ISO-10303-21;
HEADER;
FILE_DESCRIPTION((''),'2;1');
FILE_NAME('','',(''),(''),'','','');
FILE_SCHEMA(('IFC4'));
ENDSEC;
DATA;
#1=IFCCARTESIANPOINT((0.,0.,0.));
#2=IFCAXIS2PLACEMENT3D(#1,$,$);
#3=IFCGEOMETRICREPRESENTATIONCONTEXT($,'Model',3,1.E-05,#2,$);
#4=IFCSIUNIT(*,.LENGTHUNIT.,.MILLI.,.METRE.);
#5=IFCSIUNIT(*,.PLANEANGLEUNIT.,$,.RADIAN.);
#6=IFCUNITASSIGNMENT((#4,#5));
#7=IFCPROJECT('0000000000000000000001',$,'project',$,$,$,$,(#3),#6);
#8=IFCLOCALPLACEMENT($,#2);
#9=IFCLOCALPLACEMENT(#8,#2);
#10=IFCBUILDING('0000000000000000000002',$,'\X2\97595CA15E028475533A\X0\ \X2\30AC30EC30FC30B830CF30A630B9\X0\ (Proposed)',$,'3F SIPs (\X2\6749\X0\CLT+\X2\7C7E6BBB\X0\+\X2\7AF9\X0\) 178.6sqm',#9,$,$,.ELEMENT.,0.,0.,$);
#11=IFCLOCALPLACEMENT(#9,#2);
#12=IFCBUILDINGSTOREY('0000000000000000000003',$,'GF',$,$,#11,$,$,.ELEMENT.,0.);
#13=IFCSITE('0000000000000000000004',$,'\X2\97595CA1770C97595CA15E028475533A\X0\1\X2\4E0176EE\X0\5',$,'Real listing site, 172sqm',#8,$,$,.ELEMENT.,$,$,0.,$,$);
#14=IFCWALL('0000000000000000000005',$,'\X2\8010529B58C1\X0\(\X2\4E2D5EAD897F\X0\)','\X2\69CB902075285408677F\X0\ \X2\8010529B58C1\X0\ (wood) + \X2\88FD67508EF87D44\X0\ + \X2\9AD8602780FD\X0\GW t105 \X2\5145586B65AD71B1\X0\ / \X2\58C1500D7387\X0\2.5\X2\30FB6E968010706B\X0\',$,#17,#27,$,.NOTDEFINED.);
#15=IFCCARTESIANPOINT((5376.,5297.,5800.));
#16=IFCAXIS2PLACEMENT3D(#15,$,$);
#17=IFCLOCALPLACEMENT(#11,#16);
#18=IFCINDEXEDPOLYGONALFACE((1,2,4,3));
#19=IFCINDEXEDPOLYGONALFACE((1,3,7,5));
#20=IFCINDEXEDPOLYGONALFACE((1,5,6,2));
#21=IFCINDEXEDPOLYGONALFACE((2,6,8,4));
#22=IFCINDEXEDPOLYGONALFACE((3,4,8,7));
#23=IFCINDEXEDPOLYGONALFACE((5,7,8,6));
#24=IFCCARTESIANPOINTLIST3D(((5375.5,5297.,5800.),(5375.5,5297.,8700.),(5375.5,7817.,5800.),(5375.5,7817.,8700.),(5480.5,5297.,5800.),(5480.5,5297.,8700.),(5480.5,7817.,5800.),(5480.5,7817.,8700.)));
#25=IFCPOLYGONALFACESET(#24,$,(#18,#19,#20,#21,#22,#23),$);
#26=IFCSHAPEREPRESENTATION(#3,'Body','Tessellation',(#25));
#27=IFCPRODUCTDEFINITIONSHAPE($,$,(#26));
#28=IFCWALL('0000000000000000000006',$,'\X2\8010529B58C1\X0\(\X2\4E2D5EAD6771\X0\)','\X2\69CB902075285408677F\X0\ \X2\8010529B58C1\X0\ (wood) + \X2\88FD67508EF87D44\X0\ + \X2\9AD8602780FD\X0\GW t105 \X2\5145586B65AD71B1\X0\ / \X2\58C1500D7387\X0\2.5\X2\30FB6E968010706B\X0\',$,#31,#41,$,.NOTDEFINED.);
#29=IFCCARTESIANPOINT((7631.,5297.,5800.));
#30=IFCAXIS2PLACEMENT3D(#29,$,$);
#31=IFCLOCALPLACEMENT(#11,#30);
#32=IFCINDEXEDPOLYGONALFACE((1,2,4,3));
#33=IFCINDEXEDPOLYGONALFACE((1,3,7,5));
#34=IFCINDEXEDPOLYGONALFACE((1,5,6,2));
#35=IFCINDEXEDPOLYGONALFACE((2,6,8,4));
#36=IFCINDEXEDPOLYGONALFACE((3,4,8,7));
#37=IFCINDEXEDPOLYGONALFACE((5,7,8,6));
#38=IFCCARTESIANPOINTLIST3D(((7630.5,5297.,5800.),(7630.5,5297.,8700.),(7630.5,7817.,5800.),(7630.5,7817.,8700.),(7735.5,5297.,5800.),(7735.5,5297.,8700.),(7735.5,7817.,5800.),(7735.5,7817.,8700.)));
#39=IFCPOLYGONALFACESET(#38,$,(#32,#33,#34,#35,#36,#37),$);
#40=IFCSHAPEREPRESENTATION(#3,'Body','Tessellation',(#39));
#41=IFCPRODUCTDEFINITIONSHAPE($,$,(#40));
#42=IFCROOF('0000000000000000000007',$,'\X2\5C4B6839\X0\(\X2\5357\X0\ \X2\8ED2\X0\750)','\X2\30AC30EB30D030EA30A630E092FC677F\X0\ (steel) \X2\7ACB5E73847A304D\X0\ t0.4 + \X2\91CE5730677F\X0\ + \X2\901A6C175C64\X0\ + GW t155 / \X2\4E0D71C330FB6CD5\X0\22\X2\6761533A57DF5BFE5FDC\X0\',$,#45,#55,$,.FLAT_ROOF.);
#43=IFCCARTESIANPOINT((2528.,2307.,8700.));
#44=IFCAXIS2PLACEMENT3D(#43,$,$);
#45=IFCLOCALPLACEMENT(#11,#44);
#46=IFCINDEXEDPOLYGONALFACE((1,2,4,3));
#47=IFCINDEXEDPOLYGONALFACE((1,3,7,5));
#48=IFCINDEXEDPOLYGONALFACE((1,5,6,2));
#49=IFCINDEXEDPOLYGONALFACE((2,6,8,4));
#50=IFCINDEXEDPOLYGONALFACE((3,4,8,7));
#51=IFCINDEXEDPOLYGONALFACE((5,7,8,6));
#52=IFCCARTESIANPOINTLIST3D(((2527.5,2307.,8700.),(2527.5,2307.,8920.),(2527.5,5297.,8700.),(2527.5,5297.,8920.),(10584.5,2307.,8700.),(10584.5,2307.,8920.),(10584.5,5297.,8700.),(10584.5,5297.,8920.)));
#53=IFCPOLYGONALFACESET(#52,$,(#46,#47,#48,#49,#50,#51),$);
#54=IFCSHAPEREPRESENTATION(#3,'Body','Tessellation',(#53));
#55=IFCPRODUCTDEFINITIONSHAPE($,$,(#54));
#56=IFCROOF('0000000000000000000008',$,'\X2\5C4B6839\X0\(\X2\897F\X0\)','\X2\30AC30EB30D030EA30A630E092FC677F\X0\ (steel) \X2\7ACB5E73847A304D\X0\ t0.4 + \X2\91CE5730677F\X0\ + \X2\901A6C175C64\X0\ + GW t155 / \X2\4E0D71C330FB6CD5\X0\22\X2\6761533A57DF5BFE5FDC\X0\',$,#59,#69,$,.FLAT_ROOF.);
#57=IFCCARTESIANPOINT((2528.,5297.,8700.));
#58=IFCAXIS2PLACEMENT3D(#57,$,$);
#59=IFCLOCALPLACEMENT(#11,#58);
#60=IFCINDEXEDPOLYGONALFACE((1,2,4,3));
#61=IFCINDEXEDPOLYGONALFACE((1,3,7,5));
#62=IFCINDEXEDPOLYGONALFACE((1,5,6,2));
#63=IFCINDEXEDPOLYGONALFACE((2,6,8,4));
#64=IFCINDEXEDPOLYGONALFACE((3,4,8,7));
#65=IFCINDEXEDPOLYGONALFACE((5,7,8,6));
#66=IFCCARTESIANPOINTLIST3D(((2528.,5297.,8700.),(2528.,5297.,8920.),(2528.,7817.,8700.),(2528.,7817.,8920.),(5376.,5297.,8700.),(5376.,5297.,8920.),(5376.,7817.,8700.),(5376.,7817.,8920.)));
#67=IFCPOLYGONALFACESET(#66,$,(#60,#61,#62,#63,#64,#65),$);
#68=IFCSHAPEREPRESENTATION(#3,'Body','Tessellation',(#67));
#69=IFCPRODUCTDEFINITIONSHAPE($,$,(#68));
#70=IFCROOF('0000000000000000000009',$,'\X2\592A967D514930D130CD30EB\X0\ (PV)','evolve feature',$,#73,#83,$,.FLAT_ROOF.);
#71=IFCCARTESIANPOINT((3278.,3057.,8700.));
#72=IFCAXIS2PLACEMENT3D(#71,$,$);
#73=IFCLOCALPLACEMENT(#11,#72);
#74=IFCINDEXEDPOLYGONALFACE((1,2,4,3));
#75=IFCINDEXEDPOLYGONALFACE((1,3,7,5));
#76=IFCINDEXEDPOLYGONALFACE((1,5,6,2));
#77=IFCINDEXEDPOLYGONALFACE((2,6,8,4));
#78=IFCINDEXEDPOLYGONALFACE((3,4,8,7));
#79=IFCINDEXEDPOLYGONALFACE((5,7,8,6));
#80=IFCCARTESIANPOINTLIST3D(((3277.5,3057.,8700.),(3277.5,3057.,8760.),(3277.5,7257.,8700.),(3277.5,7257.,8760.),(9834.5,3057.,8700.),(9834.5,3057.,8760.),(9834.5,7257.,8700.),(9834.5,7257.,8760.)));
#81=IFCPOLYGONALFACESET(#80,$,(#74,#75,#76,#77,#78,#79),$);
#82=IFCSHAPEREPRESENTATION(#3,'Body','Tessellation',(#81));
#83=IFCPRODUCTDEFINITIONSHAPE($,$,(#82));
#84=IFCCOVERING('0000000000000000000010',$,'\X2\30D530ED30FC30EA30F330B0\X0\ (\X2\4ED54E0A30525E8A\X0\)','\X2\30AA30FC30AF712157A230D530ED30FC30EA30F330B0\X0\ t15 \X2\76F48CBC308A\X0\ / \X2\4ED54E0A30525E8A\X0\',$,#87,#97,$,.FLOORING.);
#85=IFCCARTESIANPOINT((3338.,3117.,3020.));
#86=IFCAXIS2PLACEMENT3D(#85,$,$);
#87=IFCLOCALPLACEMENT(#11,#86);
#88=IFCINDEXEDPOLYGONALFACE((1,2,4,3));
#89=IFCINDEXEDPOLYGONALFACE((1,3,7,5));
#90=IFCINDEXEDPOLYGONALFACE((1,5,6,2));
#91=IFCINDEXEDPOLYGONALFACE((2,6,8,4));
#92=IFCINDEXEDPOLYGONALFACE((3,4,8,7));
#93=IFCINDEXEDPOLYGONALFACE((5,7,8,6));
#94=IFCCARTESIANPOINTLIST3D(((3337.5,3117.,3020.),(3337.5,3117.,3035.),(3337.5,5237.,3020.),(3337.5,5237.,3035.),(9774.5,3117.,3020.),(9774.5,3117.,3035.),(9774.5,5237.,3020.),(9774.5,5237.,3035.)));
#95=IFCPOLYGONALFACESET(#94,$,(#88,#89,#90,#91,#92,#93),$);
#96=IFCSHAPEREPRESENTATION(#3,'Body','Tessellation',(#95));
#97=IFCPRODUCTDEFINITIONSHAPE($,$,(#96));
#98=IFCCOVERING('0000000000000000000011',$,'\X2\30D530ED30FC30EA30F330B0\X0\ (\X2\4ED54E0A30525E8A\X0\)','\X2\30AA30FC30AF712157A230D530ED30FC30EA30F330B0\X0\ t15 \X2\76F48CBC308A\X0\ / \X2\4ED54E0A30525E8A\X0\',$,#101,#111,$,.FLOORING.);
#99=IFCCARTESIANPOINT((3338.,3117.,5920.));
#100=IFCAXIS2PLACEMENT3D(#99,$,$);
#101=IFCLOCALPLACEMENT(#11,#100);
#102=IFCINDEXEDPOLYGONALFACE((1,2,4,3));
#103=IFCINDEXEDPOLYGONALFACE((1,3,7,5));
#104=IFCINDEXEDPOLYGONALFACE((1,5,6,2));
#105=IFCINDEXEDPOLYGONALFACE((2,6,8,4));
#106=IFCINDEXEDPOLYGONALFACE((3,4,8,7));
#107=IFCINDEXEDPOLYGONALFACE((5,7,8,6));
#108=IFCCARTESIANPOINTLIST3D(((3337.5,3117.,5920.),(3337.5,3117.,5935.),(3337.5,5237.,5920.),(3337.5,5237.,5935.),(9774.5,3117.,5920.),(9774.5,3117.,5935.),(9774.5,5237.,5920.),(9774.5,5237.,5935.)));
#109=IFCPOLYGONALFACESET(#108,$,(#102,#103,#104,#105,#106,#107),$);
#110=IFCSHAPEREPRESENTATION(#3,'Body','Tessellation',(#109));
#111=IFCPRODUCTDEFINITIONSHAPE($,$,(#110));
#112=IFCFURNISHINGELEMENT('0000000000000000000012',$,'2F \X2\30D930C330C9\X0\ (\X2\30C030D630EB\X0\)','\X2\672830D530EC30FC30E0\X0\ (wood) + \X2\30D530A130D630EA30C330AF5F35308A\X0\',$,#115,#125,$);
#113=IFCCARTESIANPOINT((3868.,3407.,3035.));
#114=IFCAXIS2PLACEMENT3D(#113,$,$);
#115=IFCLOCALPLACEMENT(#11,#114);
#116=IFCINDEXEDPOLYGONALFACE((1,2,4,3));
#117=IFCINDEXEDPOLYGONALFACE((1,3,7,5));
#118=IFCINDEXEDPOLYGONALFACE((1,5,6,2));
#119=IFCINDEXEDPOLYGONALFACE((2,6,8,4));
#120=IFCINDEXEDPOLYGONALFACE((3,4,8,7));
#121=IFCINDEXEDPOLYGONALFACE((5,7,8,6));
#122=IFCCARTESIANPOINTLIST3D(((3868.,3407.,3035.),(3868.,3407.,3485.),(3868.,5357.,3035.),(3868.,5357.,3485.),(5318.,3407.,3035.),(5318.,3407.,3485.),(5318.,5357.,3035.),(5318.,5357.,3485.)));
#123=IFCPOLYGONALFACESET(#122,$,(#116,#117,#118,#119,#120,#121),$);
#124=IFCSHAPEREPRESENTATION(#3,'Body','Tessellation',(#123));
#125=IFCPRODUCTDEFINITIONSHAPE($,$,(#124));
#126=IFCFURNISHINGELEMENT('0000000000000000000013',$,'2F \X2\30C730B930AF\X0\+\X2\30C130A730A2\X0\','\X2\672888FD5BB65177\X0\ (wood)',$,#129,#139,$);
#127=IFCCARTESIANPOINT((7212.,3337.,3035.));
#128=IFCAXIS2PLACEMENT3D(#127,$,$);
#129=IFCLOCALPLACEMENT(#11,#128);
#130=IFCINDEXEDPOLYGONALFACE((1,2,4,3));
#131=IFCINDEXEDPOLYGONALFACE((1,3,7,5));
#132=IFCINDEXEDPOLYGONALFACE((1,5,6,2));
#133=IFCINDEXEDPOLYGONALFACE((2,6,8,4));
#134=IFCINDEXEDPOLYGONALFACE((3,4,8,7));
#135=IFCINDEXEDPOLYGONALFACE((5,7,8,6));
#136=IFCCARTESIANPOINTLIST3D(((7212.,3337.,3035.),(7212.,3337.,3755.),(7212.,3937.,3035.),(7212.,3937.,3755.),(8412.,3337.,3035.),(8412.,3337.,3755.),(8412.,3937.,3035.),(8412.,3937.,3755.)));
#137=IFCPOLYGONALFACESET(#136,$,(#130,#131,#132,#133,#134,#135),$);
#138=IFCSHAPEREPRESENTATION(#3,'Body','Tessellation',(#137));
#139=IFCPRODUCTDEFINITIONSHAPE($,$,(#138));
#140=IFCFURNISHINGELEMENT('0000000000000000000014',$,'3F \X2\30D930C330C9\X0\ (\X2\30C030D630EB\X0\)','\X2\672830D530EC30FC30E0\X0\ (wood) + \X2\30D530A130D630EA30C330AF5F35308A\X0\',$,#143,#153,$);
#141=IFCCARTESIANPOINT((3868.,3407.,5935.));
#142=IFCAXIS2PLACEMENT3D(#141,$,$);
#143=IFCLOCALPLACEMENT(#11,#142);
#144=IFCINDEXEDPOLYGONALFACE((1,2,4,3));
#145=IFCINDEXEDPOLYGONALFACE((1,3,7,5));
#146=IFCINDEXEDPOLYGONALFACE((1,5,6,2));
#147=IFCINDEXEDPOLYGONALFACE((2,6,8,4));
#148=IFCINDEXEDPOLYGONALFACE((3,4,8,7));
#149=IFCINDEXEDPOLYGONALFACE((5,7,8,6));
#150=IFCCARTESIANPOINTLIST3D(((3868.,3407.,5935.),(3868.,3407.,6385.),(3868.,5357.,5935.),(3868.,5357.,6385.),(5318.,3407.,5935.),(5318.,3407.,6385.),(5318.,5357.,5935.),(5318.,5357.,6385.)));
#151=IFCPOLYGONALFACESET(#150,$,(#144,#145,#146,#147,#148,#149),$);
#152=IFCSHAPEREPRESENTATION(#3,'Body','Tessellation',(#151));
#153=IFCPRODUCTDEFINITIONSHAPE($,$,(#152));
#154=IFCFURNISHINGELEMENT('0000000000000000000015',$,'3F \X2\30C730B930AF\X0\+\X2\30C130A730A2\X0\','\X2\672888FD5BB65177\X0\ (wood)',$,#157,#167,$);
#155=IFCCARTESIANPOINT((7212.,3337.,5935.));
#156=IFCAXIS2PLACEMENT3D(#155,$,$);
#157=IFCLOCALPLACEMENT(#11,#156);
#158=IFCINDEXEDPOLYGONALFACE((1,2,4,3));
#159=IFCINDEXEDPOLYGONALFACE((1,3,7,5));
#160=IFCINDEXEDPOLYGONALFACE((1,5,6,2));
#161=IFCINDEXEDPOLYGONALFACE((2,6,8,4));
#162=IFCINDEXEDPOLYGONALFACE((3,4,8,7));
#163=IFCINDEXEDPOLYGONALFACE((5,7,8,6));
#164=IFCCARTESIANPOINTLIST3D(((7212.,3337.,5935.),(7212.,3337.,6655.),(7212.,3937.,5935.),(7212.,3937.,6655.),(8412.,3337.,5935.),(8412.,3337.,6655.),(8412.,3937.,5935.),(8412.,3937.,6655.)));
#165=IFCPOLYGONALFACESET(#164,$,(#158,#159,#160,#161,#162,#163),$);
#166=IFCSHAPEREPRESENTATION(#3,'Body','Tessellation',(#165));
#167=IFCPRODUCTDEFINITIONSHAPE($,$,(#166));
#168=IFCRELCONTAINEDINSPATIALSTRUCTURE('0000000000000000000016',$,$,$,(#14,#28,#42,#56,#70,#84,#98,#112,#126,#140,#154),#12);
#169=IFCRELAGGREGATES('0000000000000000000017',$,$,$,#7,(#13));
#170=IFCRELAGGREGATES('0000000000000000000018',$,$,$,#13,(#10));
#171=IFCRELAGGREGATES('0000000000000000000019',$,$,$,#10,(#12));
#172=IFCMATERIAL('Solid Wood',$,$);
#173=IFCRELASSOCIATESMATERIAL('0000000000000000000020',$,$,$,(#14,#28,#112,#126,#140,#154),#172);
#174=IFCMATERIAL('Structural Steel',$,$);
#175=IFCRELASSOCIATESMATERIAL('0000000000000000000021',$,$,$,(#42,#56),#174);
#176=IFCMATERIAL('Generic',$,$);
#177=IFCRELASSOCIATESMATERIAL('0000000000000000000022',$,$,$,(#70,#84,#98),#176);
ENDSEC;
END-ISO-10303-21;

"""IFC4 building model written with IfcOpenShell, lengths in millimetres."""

from ifc_helpers import new_model, si_unit, frame, frame_2d, origin, place, context, project, spatial, rectangle, extrude, material, element, save


model = new_model("IFC4")

# Units and contexts
model_context = context("Model", 3, precision=1e-05, world=origin())
ifc_project = project(units=[si_unit("LENGTHUNIT", "METRE", prefix="MILLI"), si_unit("PLANEANGLEUNIT", "RADIAN")], contexts=[model_context])

# Site, building, storey
site_placement = place(None, origin())
site = spatial("IfcSite", under=ifc_project, at=site_placement, Name="静岡県静岡市葵区1丁目5", ObjectType="Real listing site, 172sqm", CompositionType="ELEMENT", RefElevation=0.0)
building_placement = place(site_placement, origin())
building = spatial("IfcBuilding", under=site, at=building_placement, Name="静岡市葵区 ガレージハウス (Proposed)", ObjectType="3F SIPs (杉CLT+籾殻+竹) 178.6sqm", CompositionType="ELEMENT", ElevationOfRefHeight=0.0, ElevationOfTerrain=0.0)
storey_placement = place(building_placement, origin())
storey = spatial("IfcBuildingStorey", under=building, at=storey_placement, Name="GF", CompositionType="ELEMENT", Elevation=0.0)

# Shared definitions
ifc_material_1 = material(Name="Solid Wood")

# Walls
wall_1_placement = place(storey_placement, frame((5376.0, 5297.0, 5800.0)))
element("IfcWall", 1, at=wall_1_placement, inside=storey, material=ifc_material_1, Name="耐力壁(中庭西)", Description="構造用合板 耐力壁 (wood) + 製材軸組 + 高性能GW t105 充填断熱 / 壁倍率2.5・準耐火", PredefinedType="NOTDEFINED", context=model_context, shape_type="SweptSolid", body=[
    extrude(rectangle(XDim=105.0, YDim=2520.0, at=frame_2d((52.0, 1260.0))), frame((5376.0, 5297.0, 5800.0)), (0.0, 0.0, 1.0), 2900.0),
])
wall_2_placement = place(storey_placement, frame((7631.0, 5297.0, 5800.0)))
element("IfcWall", 2, at=wall_2_placement, inside=storey, material=ifc_material_1, Name="耐力壁(中庭東)", Description="構造用合板 耐力壁 (wood) + 製材軸組 + 高性能GW t105 充填断熱 / 壁倍率2.5・準耐火", PredefinedType="NOTDEFINED", context=model_context, shape_type="SweptSolid", body=[
    extrude(rectangle(XDim=105.0, YDim=2520.0, at=frame_2d((52.0, 1260.0))), frame((7631.0, 5297.0, 5800.0)), (0.0, 0.0, 1.0), 2900.0),
])

# Roofs
ifc_material_2 = material(Name="Structural Steel")
roof_1_placement = place(storey_placement, frame((2528.0, 2307.0, 8700.0)))
element("IfcRoof", 3, at=roof_1_placement, inside=storey, material=ifc_material_2, Name="屋根(南 軒750)", Description="ガルバリウム鋼板 (steel) 立平葺き t0.4 + 野地板 + 通気層 + GW t155 / 不燃・法22条区域対応", PredefinedType="FLAT_ROOF", context=model_context, shape_type="SweptSolid", body=[
    extrude(rectangle(XDim=8057.0, YDim=2990.0, at=frame_2d((4028.0, 1495.0))), frame((2528.0, 2307.0, 8700.0)), (0.0, 0.0, 1.0), 220.0),
])
roof_2_placement = place(storey_placement, frame((2528.0, 5297.0, 8700.0)))
element("IfcRoof", 4, at=roof_2_placement, inside=storey, material=ifc_material_2, Name="屋根(西)", Description="ガルバリウム鋼板 (steel) 立平葺き t0.4 + 野地板 + 通気層 + GW t155 / 不燃・法22条区域対応", PredefinedType="FLAT_ROOF", context=model_context, shape_type="SweptSolid", body=[
    extrude(rectangle(XDim=2848.0, YDim=2520.0, at=frame_2d((1424.0, 1260.0))), frame((2528.0, 5297.0, 8700.0)), (0.0, 0.0, 1.0), 220.0),
])
ifc_material_3 = material(Name="Generic")
roof_3_placement = place(storey_placement, frame((3278.0, 3057.0, 8700.0)))
element("IfcRoof", 5, at=roof_3_placement, inside=storey, material=ifc_material_3, Name="太陽光パネル (PV)", Description="evolve feature", PredefinedType="FLAT_ROOF", context=model_context, shape_type="SweptSolid", body=[
    extrude(rectangle(XDim=6557.0, YDim=4200.0, at=frame_2d((3278.0, 2100.0))), frame((3278.0, 3057.0, 8700.0)), (0.0, 0.0, 1.0), 60.0),
])

# Coverings
covering_1_placement = place(storey_placement, frame((3338.0, 3117.0, 3020.0)))
element("IfcCovering", 6, at=covering_1_placement, inside=storey, material=ifc_material_3, Name="フローリング (仕上げ床)", Description="オーク無垢フローリング t15 直貼り / 仕上げ床", PredefinedType="FLOORING", context=model_context, shape_type="SweptSolid", body=[
    extrude(rectangle(XDim=6437.0, YDim=2120.0, at=frame_2d((3218.0, 1060.0))), frame((3338.0, 3117.0, 3020.0)), (0.0, 0.0, 1.0), 15.0),
])
covering_2_placement = place(storey_placement, frame((3338.0, 3117.0, 5920.0)))
element("IfcCovering", 7, at=covering_2_placement, inside=storey, material=ifc_material_3, Name="フローリング (仕上げ床)", Description="オーク無垢フローリング t15 直貼り / 仕上げ床", PredefinedType="FLOORING", context=model_context, shape_type="SweptSolid", body=[
    extrude(rectangle(XDim=6437.0, YDim=2120.0, at=frame_2d((3218.0, 1060.0))), frame((3338.0, 3117.0, 5920.0)), (0.0, 0.0, 1.0), 15.0),
])

# Furnishing elements
furnishing_1_placement = place(storey_placement, frame((3868.0, 3407.0, 3035.0)))
element("IfcFurnishingElement", 8, at=furnishing_1_placement, inside=storey, material=ifc_material_1, Name="2F ベッド (ダブル)", Description="木フレーム (wood) + ファブリック張り", context=model_context, shape_type="SweptSolid", body=[
    extrude(rectangle(XDim=1450.0, YDim=1950.0, at=frame_2d((725.0, 975.0))), frame((3868.0, 3407.0, 3035.0)), (0.0, 0.0, 1.0), 450.0),
])
furnishing_2_placement = place(storey_placement, frame((7212.0, 3337.0, 3035.0)))
element("IfcFurnishingElement", 9, at=furnishing_2_placement, inside=storey, material=ifc_material_1, Name="2F デスク+チェア", Description="木製家具 (wood)", context=model_context, shape_type="SweptSolid", body=[
    extrude(rectangle(XDim=1200.0, YDim=600.0, at=frame_2d((600.0, 300.0))), frame((7212.0, 3337.0, 3035.0)), (0.0, 0.0, 1.0), 720.0),
])
furnishing_3_placement = place(storey_placement, frame((3868.0, 3407.0, 5935.0)))
element("IfcFurnishingElement", 10, at=furnishing_3_placement, inside=storey, material=ifc_material_1, Name="3F ベッド (ダブル)", Description="木フレーム (wood) + ファブリック張り", context=model_context, shape_type="SweptSolid", body=[
    extrude(rectangle(XDim=1450.0, YDim=1950.0, at=frame_2d((725.0, 975.0))), frame((3868.0, 3407.0, 5935.0)), (0.0, 0.0, 1.0), 450.0),
])
furnishing_4_placement = place(storey_placement, frame((7212.0, 3337.0, 5935.0)))
element("IfcFurnishingElement", 11, at=furnishing_4_placement, inside=storey, material=ifc_material_1, Name="3F デスク+チェア", Description="木製家具 (wood)", context=model_context, shape_type="SweptSolid", body=[
    extrude(rectangle(XDim=1200.0, YDim=600.0, at=frame_2d((600.0, 300.0))), frame((7212.0, 3337.0, 5935.0)), (0.0, 0.0, 1.0), 720.0),
])

save(model, "model.ifc")
